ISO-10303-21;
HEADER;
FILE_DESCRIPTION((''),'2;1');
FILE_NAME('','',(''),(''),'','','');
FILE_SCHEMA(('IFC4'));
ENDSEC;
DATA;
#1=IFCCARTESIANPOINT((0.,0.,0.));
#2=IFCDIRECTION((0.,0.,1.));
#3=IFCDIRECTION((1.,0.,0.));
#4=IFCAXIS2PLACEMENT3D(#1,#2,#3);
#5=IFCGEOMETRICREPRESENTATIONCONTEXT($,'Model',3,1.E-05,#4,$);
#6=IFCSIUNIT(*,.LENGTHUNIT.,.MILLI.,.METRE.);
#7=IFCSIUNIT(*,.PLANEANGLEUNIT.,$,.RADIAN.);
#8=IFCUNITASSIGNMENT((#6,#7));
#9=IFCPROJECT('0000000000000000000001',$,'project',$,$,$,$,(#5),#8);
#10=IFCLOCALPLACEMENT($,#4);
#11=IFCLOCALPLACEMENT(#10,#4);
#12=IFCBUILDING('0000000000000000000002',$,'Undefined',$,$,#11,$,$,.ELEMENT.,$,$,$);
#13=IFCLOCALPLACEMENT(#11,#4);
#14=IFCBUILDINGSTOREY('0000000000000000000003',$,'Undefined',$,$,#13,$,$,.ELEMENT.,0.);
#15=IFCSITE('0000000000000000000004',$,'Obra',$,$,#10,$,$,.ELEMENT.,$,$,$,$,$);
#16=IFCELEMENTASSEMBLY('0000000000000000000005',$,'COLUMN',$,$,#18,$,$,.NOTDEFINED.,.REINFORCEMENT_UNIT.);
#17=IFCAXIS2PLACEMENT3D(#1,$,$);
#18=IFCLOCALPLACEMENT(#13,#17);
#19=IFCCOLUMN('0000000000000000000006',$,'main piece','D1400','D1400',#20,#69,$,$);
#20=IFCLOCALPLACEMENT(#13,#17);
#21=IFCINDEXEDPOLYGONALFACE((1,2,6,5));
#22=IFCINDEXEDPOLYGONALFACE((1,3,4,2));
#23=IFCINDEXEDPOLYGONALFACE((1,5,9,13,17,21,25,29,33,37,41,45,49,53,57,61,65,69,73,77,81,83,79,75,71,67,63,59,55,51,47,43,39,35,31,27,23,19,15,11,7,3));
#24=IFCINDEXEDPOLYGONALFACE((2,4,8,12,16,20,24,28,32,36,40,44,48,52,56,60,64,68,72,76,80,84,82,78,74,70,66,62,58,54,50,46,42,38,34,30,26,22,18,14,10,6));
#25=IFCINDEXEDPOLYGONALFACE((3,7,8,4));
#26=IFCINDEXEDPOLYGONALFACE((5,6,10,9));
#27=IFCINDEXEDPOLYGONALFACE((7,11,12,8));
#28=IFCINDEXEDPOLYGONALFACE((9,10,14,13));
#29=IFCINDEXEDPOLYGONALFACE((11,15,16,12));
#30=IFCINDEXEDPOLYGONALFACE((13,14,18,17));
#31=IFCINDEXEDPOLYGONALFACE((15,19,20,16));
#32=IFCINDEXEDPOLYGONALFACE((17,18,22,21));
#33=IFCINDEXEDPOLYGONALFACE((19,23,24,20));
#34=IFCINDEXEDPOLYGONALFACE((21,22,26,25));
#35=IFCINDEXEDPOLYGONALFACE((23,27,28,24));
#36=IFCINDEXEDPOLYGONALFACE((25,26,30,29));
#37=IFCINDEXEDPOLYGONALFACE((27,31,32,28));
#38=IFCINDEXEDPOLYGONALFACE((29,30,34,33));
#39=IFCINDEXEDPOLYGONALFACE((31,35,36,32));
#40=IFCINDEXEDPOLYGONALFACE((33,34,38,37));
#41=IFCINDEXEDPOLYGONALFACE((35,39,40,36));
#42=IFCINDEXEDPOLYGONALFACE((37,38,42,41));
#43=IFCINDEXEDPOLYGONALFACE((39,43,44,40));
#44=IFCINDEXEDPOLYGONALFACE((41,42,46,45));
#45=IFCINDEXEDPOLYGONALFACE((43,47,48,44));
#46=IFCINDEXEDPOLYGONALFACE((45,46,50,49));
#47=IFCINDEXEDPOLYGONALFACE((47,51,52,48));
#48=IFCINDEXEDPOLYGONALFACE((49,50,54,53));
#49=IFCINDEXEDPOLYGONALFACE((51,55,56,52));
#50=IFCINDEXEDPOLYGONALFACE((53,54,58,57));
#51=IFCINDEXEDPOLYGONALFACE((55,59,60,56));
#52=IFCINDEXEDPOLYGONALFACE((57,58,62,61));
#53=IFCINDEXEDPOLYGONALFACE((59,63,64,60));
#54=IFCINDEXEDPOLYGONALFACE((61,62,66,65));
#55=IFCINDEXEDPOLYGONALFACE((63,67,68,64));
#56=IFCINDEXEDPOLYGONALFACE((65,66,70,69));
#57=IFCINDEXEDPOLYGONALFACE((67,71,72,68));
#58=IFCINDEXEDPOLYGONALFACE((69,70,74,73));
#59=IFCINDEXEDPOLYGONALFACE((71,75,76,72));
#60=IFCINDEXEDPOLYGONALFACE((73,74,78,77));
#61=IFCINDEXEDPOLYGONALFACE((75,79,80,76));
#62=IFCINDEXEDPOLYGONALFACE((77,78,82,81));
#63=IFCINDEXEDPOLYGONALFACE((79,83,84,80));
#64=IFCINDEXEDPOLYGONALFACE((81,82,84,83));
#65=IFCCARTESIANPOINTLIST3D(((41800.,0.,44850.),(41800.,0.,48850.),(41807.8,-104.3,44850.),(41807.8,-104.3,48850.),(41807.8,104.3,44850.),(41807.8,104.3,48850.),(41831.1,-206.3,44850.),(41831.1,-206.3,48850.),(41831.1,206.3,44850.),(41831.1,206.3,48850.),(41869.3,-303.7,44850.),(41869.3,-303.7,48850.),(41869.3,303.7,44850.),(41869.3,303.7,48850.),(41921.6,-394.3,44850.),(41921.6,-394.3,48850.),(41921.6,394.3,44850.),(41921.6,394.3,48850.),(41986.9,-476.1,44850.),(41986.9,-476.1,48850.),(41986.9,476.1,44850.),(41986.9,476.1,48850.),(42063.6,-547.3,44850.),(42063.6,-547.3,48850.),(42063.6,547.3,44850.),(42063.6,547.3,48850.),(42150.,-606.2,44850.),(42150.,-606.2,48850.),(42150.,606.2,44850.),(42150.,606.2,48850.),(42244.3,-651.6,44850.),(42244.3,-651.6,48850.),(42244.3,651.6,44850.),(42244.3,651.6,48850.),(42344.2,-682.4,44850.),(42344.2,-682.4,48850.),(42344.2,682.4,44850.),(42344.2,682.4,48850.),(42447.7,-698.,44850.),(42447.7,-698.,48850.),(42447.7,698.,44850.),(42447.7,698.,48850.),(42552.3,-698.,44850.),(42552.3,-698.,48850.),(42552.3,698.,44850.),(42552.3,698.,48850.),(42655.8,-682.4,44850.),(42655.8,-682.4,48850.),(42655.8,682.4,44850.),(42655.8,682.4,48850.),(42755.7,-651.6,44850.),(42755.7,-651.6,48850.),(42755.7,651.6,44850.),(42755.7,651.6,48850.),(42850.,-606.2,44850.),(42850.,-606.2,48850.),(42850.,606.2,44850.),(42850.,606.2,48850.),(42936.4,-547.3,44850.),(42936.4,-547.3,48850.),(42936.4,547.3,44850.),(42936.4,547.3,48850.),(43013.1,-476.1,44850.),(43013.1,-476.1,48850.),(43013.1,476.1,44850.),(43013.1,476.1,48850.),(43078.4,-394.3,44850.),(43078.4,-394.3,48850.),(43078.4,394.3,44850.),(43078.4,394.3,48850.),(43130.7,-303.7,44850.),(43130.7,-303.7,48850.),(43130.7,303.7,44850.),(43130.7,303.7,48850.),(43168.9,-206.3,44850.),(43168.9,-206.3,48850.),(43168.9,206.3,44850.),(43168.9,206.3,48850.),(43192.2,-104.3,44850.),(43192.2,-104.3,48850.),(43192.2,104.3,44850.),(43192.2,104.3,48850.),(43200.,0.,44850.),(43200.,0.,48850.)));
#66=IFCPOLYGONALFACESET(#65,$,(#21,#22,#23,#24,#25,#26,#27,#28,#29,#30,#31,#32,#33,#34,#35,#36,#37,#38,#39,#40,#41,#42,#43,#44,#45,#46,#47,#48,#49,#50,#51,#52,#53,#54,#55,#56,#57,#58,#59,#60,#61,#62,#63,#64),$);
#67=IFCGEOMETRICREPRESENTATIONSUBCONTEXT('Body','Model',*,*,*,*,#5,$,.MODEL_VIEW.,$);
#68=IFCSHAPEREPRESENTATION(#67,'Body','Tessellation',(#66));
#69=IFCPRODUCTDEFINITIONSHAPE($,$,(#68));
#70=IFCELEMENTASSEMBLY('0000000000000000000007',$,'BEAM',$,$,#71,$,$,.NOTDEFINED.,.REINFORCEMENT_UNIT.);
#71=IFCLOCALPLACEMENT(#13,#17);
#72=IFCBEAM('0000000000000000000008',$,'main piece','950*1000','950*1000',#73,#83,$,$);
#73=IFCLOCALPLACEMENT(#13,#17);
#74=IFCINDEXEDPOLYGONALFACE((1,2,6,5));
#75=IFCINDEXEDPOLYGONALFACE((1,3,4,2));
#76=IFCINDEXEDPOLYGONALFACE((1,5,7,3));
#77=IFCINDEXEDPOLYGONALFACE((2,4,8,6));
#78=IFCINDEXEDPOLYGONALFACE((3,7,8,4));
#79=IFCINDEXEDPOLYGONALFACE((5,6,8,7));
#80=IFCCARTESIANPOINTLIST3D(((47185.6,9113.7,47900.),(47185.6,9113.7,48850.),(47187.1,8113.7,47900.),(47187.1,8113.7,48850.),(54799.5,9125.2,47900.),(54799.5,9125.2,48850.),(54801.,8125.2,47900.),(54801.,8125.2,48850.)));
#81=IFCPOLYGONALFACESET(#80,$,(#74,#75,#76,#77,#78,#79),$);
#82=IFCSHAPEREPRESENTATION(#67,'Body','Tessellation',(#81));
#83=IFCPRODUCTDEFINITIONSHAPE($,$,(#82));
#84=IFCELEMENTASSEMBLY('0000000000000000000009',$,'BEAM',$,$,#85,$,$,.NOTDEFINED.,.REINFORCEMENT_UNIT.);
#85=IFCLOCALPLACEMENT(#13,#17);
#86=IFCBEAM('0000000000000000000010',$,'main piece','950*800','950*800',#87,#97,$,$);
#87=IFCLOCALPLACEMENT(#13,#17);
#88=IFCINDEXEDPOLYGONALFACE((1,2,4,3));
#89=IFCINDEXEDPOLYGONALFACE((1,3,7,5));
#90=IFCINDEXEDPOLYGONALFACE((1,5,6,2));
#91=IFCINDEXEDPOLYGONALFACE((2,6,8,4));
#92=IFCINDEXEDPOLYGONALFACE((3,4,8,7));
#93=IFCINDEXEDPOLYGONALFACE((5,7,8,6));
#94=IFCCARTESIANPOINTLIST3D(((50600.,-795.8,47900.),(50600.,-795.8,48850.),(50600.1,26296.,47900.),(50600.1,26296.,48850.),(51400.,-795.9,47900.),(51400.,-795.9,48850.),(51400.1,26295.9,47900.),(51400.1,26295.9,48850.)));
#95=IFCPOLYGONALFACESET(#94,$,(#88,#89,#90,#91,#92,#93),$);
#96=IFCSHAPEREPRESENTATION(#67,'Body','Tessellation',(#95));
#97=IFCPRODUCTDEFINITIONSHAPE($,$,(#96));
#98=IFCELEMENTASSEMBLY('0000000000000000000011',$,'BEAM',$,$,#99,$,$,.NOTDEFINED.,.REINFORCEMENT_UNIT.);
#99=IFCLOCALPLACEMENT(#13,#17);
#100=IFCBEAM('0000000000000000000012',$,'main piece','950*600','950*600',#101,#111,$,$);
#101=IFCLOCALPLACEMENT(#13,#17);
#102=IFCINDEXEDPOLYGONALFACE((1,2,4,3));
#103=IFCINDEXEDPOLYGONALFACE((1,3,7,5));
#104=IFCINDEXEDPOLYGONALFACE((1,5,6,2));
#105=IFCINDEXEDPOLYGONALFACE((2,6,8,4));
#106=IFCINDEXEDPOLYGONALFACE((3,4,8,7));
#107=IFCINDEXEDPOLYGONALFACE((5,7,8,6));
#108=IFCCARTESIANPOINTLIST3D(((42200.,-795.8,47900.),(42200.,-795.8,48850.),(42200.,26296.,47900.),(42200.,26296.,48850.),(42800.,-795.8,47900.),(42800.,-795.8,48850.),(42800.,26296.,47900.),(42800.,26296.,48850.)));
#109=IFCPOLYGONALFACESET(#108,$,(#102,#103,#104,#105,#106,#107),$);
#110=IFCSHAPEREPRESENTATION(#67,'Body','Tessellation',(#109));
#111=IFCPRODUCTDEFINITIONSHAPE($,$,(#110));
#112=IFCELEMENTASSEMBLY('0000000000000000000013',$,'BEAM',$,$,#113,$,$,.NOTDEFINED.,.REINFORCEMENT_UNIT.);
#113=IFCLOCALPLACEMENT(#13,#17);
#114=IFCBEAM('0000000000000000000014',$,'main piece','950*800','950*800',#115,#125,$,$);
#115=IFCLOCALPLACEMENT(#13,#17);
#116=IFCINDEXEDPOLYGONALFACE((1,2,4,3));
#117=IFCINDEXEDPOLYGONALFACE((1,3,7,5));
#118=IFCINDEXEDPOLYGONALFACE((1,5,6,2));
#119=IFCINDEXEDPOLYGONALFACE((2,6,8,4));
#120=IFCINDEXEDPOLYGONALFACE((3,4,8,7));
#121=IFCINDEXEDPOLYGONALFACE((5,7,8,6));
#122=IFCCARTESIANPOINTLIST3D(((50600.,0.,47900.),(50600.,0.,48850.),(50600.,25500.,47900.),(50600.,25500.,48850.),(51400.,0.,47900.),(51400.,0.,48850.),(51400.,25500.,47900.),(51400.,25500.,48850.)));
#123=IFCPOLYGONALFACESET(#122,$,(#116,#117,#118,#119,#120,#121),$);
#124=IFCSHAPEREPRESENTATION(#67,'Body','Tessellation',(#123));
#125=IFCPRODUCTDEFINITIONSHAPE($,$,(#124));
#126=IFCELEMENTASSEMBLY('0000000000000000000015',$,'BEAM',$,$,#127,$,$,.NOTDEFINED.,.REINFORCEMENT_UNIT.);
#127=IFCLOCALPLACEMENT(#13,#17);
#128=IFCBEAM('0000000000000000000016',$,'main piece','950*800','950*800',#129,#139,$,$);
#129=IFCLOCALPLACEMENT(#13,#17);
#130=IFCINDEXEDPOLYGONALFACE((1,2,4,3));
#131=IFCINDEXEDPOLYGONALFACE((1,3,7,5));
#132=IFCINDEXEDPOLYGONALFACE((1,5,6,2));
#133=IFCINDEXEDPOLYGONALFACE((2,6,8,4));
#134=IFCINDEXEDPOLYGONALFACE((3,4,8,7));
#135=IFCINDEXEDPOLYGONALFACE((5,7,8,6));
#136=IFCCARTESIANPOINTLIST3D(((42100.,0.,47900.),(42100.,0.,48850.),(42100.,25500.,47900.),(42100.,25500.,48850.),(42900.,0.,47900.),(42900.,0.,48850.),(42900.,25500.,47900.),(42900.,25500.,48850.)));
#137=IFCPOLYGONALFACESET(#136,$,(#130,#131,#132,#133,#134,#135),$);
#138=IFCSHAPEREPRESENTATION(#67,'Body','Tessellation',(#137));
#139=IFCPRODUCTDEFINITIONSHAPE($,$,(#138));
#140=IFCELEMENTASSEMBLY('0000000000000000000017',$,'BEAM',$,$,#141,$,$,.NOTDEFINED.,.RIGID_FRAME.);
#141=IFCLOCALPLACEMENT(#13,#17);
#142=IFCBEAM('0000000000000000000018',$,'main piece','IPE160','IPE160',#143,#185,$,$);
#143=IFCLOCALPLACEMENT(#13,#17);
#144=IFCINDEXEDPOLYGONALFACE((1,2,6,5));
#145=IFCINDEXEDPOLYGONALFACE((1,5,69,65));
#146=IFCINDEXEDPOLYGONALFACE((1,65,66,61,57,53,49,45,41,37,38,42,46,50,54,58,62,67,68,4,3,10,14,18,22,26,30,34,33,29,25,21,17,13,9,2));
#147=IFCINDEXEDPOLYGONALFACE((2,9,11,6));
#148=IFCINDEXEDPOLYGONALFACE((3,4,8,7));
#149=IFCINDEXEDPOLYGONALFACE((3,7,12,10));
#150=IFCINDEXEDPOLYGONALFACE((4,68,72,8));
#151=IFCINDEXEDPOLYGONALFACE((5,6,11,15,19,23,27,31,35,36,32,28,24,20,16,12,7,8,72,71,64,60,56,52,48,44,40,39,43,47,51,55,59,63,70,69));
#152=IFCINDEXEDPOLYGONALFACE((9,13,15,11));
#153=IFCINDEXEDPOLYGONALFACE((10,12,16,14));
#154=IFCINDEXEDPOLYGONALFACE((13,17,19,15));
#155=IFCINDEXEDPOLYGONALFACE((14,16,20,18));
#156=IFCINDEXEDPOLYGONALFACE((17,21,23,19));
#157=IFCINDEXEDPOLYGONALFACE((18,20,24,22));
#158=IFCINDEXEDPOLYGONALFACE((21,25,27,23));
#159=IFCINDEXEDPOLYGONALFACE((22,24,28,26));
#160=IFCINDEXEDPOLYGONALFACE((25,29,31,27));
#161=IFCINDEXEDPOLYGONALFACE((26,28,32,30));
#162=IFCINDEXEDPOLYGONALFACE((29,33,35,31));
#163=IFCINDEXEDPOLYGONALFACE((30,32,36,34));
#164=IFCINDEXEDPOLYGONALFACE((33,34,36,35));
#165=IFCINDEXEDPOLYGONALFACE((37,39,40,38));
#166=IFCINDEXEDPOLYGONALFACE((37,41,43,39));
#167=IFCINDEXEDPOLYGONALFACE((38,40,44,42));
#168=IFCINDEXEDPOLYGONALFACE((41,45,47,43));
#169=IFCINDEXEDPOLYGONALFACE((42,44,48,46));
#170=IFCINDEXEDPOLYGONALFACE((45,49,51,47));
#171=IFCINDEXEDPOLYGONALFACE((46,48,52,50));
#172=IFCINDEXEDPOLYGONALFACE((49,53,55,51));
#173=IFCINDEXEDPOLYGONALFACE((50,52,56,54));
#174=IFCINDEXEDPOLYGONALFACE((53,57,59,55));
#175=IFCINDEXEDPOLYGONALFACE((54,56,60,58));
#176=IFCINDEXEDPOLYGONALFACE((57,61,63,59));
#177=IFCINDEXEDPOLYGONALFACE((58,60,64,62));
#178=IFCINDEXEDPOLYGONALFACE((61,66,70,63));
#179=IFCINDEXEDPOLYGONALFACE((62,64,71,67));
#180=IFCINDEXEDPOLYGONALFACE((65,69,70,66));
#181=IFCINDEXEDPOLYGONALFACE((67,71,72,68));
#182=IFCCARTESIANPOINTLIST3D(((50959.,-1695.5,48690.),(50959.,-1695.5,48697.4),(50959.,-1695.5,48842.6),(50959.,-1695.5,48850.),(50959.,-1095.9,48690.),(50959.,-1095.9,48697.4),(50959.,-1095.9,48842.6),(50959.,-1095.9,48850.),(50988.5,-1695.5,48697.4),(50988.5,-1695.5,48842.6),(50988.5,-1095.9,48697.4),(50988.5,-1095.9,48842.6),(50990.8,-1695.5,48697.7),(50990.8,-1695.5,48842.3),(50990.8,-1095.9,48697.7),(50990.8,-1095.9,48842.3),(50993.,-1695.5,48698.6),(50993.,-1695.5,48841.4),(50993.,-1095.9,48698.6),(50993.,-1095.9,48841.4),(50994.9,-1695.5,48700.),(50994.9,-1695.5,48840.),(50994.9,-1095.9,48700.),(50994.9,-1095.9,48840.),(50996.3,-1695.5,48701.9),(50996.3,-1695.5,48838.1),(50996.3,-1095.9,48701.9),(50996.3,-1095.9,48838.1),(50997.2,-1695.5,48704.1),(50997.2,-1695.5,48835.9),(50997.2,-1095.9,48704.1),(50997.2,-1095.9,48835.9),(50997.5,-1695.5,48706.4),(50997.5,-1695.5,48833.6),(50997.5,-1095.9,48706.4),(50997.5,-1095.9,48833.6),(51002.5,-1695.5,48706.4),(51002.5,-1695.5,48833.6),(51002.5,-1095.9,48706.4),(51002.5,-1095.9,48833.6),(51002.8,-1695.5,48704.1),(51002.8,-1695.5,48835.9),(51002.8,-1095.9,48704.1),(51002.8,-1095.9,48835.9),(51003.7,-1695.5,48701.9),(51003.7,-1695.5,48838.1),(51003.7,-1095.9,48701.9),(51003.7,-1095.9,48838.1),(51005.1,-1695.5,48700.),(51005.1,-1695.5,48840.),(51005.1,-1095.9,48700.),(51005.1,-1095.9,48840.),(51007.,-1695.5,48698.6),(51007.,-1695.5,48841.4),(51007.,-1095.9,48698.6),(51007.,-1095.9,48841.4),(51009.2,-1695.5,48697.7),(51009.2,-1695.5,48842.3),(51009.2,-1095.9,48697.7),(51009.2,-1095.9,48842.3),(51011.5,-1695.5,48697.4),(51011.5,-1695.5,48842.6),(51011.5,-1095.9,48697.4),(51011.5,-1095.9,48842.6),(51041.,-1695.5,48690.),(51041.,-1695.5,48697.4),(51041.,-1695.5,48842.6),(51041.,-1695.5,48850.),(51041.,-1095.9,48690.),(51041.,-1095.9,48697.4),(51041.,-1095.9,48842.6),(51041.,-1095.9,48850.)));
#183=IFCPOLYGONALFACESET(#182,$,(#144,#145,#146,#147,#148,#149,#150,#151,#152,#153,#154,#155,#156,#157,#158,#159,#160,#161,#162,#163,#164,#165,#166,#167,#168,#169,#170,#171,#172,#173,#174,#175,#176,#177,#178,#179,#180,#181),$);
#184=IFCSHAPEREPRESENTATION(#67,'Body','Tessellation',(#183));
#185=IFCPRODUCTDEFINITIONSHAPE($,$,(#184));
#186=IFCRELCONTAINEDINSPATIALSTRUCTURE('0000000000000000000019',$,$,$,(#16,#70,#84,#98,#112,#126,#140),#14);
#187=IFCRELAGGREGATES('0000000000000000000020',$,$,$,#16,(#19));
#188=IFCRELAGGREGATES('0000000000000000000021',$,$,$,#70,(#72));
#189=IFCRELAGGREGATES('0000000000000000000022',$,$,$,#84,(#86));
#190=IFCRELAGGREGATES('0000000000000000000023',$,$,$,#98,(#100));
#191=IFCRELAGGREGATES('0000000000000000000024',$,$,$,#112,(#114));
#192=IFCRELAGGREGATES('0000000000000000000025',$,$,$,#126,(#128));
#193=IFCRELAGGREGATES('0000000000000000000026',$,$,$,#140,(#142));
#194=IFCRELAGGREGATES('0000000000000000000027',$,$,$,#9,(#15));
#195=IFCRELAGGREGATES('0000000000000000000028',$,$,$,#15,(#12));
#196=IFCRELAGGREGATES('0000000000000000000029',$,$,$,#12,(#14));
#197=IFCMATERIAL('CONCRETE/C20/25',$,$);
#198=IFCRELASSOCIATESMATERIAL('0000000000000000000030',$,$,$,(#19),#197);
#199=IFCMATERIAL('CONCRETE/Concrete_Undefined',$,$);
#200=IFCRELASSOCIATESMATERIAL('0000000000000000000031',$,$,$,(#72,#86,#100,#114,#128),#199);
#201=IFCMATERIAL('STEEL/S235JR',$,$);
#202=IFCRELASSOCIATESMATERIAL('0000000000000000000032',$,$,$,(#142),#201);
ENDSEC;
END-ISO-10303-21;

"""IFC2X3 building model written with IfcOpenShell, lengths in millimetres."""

from ifc_helpers import new_model, si_unit, frame, origin_with_axes, origin_2d_with_axis, place, context, subcontext, project, spatial, rectangle, circle, i_section, extrude, material, element, aggregate, save


model = new_model("IFC2X3")

# Units and contexts
model_context = context("Model", 3, precision=1e-05, world=origin_with_axes())
body_context = subcontext(model_context, "Body", "Model", "MODEL_VIEW")
ifc_project = project(units=[si_unit("LENGTHUNIT", "METRE", prefix="MILLI"), si_unit("PLANEANGLEUNIT", "RADIAN")], contexts=[model_context])

# Site, building, storey
site_placement = place(None, origin_with_axes())
site = spatial("IfcSite", under=ifc_project, at=site_placement, Name="Obra", CompositionType="ELEMENT")
building_placement = place(site_placement, origin_with_axes())
building = spatial("IfcBuilding", under=site, at=building_placement, Name="Undefined", CompositionType="ELEMENT")
storey_placement = place(building_placement, origin_with_axes())
storey = spatial("IfcBuildingStorey", under=building, at=storey_placement, Name="Undefined", CompositionType="ELEMENT", Elevation=0.0)

# Element assembly, column
ifc_material_1 = material(Name="STEEL/S235JR")
ifc_material_2 = material(Name="CONCRETE/C20/25")
assembly_1_placement = place(storey_placement, origin_with_axes())
assembly_1 = element("IfcElementAssembly", 1, at=assembly_1_placement, inside=storey, Name="COLUMN", AssemblyPlace="NOTDEFINED", PredefinedType="REINFORCEMENT_UNIT")
column_1_placement = place(assembly_1_placement, frame((42500.0, 0.0, 44850.0), z_axis=(0.0, 0.0, 1.0), x_axis=(0.0, 1.0, 0.0)))
column_1 = element("IfcColumn", 2, at=column_1_placement, material=ifc_material_2, Name="main piece", Description="D1400", ObjectType="D1400", context=body_context, shape_type="SweptSolid", body=[
    extrude(circle(Radius=700.0, at=origin_2d_with_axis()), frame((0.0, 0.0, 4000.0), z_axis=(0.0, 0.0, -1.0), x_axis=(0.0, 1.0, 0.0)), (0.0, 0.0, 1.0), 4000.0),
])
aggregate(assembly_1, [column_1])

# Element assemblies, beams
assembly_2_placement = place(storey_placement, origin_with_axes())
assembly_2 = element("IfcElementAssembly", 3, at=assembly_2_placement, inside=storey, Name="BEAM", AssemblyPlace="NOTDEFINED", PredefinedType="REINFORCEMENT_UNIT")
ifc_material_3 = material(Name="CONCRETE/Concrete_Undefined")
beam_1_placement = place(assembly_2_placement, frame((47186.4, 8613.7, 48375.0), z_axis=(0.0, 0.0, 1.0), x_axis=(0.999999, 0.001508, 0.0)))
beam_1 = element("IfcBeam", 4, at=beam_1_placement, material=ifc_material_3, Name="main piece", Description="950*1000", ObjectType="950*1000", context=body_context, shape_type="SweptSolid", body=[
    extrude(rectangle(XDim=1000.0, YDim=950.0, at=origin_2d_with_axis()), frame((7613.8, 0.0, 0.0), z_axis=(-1.0, 0.0, 0.0), x_axis=(0.0, -1.0, 0.0)), (0.0, 0.0, 1.0), 7613.8),
])
aggregate(assembly_2, [beam_1])
assembly_3_placement = place(storey_placement, origin_with_axes())
assembly_3 = element("IfcElementAssembly", 5, at=assembly_3_placement, inside=storey, Name="BEAM", AssemblyPlace="NOTDEFINED", PredefinedType="REINFORCEMENT_UNIT")
beam_2_placement = place(assembly_3_placement, frame((51000.0, -795.8, 48375.0), z_axis=(0.0, 0.0, 1.0), x_axis=(0.000003, 1.0, 0.0)))
beam_2 = element("IfcBeam", 6, at=beam_2_placement, material=ifc_material_3, Name="main piece", Description="950*800", ObjectType="950*800", context=body_context, shape_type="SweptSolid", body=[
    extrude(rectangle(XDim=800.0, YDim=950.0, at=origin_2d_with_axis()), frame((27091.8, 0.0, 0.0), z_axis=(-1.0, 0.0, 0.0), x_axis=(0.0, -1.0, 0.0)), (0.0, 0.0, 1.0), 27091.8),
])
aggregate(assembly_3, [beam_2])
assembly_4_placement = place(storey_placement, origin_with_axes())
assembly_4 = element("IfcElementAssembly", 7, at=assembly_4_placement, inside=storey, Name="BEAM", AssemblyPlace="NOTDEFINED", PredefinedType="REINFORCEMENT_UNIT")
beam_3_placement = place(assembly_4_placement, frame((42500.0, -795.8, 48375.0), z_axis=(0.0, 0.0, 1.0), x_axis=(0.0, 1.0, 0.0)))
beam_3 = element("IfcBeam", 8, at=beam_3_placement, material=ifc_material_3, Name="main piece", Description="950*600", ObjectType="950*600", context=body_context, shape_type="SweptSolid", body=[
    extrude(rectangle(XDim=600.0, YDim=950.0, at=origin_2d_with_axis()), frame((27091.8, 0.0, 0.0), z_axis=(-1.0, 0.0, 0.0), x_axis=(0.0, -1.0, 0.0)), (0.0, 0.0, 1.0), 27091.8),
])
aggregate(assembly_4, [beam_3])
assembly_5_placement = place(storey_placement, origin_with_axes())
assembly_5 = element("IfcElementAssembly", 9, at=assembly_5_placement, inside=storey, Name="BEAM", AssemblyPlace="NOTDEFINED", PredefinedType="REINFORCEMENT_UNIT")
beam_4_placement = place(assembly_5_placement, frame((51000.0, 0.0, 48375.0), z_axis=(0.0, 0.0, 1.0), x_axis=(0.0, 1.0, 0.0)))
beam_4 = element("IfcBeam", 10, at=beam_4_placement, material=ifc_material_3, Name="main piece", Description="950*800", ObjectType="950*800", context=body_context, shape_type="SweptSolid", body=[
    extrude(rectangle(XDim=800.0, YDim=950.0, at=origin_2d_with_axis()), frame((25500.0, 0.0, 0.0), z_axis=(-1.0, 0.0, 0.0), x_axis=(0.0, -1.0, 0.0)), (0.0, 0.0, 1.0), 25500.0),
])
aggregate(assembly_5, [beam_4])
assembly_6_placement = place(storey_placement, origin_with_axes())
assembly_6 = element("IfcElementAssembly", 11, at=assembly_6_placement, inside=storey, Name="BEAM", AssemblyPlace="NOTDEFINED", PredefinedType="REINFORCEMENT_UNIT")
beam_5_placement = place(assembly_6_placement, frame((42500.0, 0.0, 48375.0), z_axis=(0.0, 0.0, 1.0), x_axis=(0.0, 1.0, 0.0)))
beam_5 = element("IfcBeam", 12, at=beam_5_placement, material=ifc_material_3, Name="main piece", Description="950*800", ObjectType="950*800", context=body_context, shape_type="SweptSolid", body=[
    extrude(rectangle(XDim=800.0, YDim=950.0, at=origin_2d_with_axis()), frame((25500.0, 0.0, 0.0), z_axis=(-1.0, 0.0, 0.0), x_axis=(0.0, -1.0, 0.0)), (0.0, 0.0, 1.0), 25500.0),
])
aggregate(assembly_6, [beam_5])
assembly_7_placement = place(storey_placement, origin_with_axes())
assembly_7 = element("IfcElementAssembly", 13, at=assembly_7_placement, inside=storey, Name="BEAM", AssemblyPlace="NOTDEFINED", PredefinedType="RIGID_FRAME")
beam_6_placement = place(assembly_7_placement, frame((51000.0, -1095.9, 48770.0), z_axis=(0.0, 0.0, 1.0), x_axis=(0.000002, -1.0, 0.0)))
beam_6 = element("IfcBeam", 14, at=beam_6_placement, material=ifc_material_1, Name="main piece", Description="IPE160", ObjectType="IPE160", context=body_context, shape_type="SweptSolid", body=[
    extrude(i_section(OverallWidth=82.0, OverallDepth=160.0, WebThickness=5.0, FlangeThickness=7.4, FilletRadius=9.0, at=origin_2d_with_axis()), frame((599.6, 0.0, 0.0), z_axis=(-1.0, 0.0, 0.0), x_axis=(0.0, -1.0, 0.0)), (0.0, 0.0, 1.0), 599.6),
])
aggregate(assembly_7, [beam_6])

save(model, "model.ifc")
